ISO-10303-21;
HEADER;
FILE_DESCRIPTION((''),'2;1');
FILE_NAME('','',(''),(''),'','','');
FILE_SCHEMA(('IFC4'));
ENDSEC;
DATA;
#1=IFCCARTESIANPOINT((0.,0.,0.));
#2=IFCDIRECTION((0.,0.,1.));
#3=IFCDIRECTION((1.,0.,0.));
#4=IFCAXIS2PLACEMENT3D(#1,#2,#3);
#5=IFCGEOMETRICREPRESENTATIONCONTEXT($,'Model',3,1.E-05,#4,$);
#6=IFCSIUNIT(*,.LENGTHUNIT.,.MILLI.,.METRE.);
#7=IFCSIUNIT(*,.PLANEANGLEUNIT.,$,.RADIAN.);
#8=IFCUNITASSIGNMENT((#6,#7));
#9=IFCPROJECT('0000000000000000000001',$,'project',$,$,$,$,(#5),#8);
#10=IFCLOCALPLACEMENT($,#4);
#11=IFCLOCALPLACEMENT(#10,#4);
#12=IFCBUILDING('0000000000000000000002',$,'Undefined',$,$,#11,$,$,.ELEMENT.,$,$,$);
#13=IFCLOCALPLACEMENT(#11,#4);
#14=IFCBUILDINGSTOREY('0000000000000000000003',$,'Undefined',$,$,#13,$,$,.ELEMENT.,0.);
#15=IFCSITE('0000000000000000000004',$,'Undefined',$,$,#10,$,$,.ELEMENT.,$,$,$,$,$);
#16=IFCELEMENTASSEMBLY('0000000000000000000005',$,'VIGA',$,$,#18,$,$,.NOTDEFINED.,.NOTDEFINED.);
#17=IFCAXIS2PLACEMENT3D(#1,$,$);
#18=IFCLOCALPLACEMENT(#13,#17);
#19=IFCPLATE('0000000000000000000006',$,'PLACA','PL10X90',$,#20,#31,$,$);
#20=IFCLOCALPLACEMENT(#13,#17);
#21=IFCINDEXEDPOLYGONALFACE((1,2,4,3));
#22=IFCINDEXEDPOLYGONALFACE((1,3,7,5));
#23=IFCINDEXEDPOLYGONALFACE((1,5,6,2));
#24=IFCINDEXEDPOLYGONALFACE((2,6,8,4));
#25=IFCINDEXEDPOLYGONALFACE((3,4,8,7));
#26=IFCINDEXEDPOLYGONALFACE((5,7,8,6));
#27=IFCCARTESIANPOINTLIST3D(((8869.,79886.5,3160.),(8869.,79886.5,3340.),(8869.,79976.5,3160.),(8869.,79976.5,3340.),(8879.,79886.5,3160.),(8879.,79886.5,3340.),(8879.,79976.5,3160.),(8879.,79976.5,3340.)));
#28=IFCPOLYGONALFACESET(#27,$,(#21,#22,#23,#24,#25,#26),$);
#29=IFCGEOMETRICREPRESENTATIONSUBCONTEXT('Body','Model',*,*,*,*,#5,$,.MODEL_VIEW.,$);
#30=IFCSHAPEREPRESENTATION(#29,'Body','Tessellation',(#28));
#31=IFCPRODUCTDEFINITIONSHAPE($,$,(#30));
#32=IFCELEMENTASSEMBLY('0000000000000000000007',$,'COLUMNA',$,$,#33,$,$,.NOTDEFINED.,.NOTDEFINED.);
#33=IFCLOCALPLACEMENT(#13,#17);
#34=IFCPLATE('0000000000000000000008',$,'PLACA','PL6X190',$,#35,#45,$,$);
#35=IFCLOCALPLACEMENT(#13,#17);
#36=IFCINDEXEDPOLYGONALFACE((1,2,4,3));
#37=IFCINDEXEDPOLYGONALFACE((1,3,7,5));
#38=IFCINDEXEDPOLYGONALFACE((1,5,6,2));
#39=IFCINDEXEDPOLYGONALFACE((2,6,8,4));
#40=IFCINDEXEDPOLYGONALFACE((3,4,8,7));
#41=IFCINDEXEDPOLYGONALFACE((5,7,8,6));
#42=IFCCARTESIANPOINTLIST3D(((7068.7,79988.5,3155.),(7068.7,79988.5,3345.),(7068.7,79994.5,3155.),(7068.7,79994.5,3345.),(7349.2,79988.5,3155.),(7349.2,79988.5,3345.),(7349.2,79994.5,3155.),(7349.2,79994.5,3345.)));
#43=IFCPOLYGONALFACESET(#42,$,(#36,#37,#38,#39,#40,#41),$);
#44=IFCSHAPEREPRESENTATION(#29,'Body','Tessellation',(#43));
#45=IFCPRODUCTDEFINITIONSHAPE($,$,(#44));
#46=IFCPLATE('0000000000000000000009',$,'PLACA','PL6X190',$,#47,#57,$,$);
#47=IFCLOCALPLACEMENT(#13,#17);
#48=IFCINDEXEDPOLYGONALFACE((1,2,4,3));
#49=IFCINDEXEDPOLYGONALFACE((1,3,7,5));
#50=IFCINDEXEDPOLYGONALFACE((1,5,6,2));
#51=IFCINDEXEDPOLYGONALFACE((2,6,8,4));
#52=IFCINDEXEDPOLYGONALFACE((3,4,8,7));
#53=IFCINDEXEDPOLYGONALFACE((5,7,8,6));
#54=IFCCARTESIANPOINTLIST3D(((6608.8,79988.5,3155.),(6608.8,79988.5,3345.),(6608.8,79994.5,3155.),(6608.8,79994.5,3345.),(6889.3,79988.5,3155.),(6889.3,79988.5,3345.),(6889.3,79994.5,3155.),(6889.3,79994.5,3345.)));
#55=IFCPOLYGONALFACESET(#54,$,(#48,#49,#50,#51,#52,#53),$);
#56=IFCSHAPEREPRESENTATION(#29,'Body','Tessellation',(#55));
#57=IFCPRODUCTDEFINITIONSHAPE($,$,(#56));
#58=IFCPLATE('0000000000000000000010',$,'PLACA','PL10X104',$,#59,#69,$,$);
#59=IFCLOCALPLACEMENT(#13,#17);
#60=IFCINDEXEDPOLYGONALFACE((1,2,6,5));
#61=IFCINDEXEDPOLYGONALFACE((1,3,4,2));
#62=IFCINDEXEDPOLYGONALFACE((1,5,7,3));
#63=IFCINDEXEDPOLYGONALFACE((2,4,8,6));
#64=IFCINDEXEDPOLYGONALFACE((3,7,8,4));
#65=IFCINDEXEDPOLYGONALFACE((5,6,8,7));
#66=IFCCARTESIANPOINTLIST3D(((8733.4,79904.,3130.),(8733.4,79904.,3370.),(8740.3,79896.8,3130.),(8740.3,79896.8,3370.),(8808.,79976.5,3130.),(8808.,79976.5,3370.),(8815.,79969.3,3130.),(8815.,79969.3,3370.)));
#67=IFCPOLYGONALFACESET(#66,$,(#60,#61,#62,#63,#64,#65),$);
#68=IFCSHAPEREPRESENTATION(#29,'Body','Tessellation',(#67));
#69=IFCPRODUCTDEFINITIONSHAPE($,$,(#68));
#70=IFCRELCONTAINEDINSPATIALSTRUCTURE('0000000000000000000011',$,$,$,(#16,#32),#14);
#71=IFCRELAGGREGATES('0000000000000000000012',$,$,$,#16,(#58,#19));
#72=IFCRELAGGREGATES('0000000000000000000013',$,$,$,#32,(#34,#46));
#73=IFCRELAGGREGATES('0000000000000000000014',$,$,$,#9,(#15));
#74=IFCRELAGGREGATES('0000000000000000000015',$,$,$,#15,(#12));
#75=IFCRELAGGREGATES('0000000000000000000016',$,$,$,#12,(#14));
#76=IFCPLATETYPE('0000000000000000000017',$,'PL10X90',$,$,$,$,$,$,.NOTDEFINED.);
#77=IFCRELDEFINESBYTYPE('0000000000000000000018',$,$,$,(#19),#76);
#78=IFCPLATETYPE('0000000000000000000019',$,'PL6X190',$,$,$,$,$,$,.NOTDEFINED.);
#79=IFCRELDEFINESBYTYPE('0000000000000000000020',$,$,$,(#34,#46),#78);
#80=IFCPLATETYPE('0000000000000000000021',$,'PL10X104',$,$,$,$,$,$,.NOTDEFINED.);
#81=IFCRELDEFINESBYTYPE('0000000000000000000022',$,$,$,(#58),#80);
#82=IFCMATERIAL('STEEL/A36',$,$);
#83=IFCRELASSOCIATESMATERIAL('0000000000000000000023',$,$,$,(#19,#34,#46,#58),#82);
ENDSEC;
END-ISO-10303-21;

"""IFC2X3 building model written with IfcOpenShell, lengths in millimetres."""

from ifc_helpers import new_model, si_unit, frame, origin_with_axes, place, context, subcontext, project, spatial, polyline, outline, extrude, material, type_object, element, aggregate, save


model = new_model("IFC2X3")

# Units and contexts
model_context = context("Model", 3, precision=1e-05, world=origin_with_axes())
body_context = subcontext(model_context, "Body", "Model", "MODEL_VIEW")
ifc_project = project(units=[si_unit("LENGTHUNIT", "METRE", prefix="MILLI"), si_unit("PLANEANGLEUNIT", "RADIAN")], contexts=[model_context])

# Site, building, storey
site_placement = place(None, origin_with_axes())
site = spatial("IfcSite", under=ifc_project, at=site_placement, Name="Undefined", CompositionType="ELEMENT")
building_placement = place(site_placement, origin_with_axes())
building = spatial("IfcBuilding", under=site, at=building_placement, Name="Undefined", CompositionType="ELEMENT")
storey_placement = place(building_placement, origin_with_axes())
storey = spatial("IfcBuildingStorey", under=building, at=storey_placement, Name="Undefined", CompositionType="ELEMENT", Elevation=0.0)

# Shared definitions
ifc_material_1 = material(Name="STEEL/A36")

# Element assembly
assembly_1_placement = place(storey_placement, origin_with_axes())
assembly_1 = element("IfcElementAssembly", 1, at=assembly_1_placement, inside=storey, Name="VIGA", AssemblyPlace="NOTDEFINED", PredefinedType="NOTDEFINED")

# Shared definitions
plate_type_1 = type_object("IfcPlateType", Name="PL10X90", PredefinedType="NOTDEFINED")

# Plate
plate_1_placement = place(assembly_1_placement, frame((8874.0, 79976.5, 3340.0), z_axis=(-1.0, 0.0, 0.0), x_axis=(0.0, 0.0, -1.0)))
plate_1 = element("IfcPlate", 2, at=plate_1_placement, type_object=plate_type_1, material=ifc_material_1, Name="PLACA", Description="PL10X90", context=body_context, shape_type="SweptSolid", body=[
    extrude(outline(polyline([(0.0, 0.0), (180.0, 0.0), (180.0, 90.0), (0.0, 90.0), (0.0, 0.0)])), frame((0.0, 0.0, -5.0), z_axis=(0.0, 0.0, 1.0), x_axis=(1.0, 0.0, 0.0)), (0.0, 0.0, 1.0), 10.0),
])

# Element assembly, plates
assembly_2_placement = place(storey_placement, origin_with_axes())
assembly_2 = element("IfcElementAssembly", 3, at=assembly_2_placement, inside=storey, Name="COLUMNA", AssemblyPlace="NOTDEFINED", PredefinedType="NOTDEFINED")
plate_type_2 = type_object("IfcPlateType", Name="PL6X190", PredefinedType="NOTDEFINED")
plate_2_placement = place(assembly_2_placement, frame((7349.2, 79991.5, 3250.0), z_axis=(0.0, 1.0, 0.0), x_axis=(-1.0, 0.0, 0.0)))
plate_2 = element("IfcPlate", 4, at=plate_2_placement, type_object=plate_type_2, material=ifc_material_1, Name="PLACA", Description="PL6X190", context=body_context, shape_type="SweptSolid", body=[
    extrude(outline(polyline([(0.0, -95.0), (0.0, 95.0), (280.5, 95.0), (280.5, -95.0), (0.0, -95.0)])), frame((0.0, 0.0, -3.0), z_axis=(0.0, 0.0, 1.0), x_axis=(1.0, 0.0, 0.0)), (0.0, 0.0, 1.0), 6.0),
])
plate_3_placement = place(assembly_2_placement, frame((6608.8, 79991.5, 3250.0), z_axis=(0.0, -1.0, 0.0), x_axis=(1.0, 0.0, 0.0)))
plate_3 = element("IfcPlate", 5, at=plate_3_placement, type_object=plate_type_2, material=ifc_material_1, Name="PLACA", Description="PL6X190", context=body_context, shape_type="SweptSolid", body=[
    extrude(outline(polyline([(0.0, -95.0), (0.0, 95.0), (280.5, 95.0), (280.5, -95.0), (0.0, -95.0)])), frame((0.0, 0.0, -3.0), z_axis=(0.0, 0.0, 1.0), x_axis=(1.0, 0.0, 0.0)), (0.0, 0.0, 1.0), 6.0),
])

# Plate
plate_type_3 = type_object("IfcPlateType", Name="PL10X104", PredefinedType="NOTDEFINED")
plate_4_placement = place(assembly_1_placement, frame((8811.5, 79972.9, 3370.0), z_axis=(-0.696651, 0.71741, 0.0), x_axis=(0.0, 0.0, -1.0)))
plate_4 = element("IfcPlate", 6, at=plate_4_placement, type_object=plate_type_3, material=ifc_material_1, Name="PLACA", Description="PL10X104", context=body_context, shape_type="SweptSolid", body=[
    extrude(outline(polyline([(0.0, 0.0), (240.0, 0.0), (240.0, 104.1), (0.0, 104.1), (0.0, 0.0)])), frame((0.0, 0.0, -5.0), z_axis=(0.0, 0.0, 1.0), x_axis=(1.0, 0.0, 0.0)), (0.0, 0.0, 1.0), 10.0),
])
aggregate(assembly_1, [plate_4, plate_1])

aggregate(assembly_2, [plate_2, plate_3])

save(model, "model.ifc")
